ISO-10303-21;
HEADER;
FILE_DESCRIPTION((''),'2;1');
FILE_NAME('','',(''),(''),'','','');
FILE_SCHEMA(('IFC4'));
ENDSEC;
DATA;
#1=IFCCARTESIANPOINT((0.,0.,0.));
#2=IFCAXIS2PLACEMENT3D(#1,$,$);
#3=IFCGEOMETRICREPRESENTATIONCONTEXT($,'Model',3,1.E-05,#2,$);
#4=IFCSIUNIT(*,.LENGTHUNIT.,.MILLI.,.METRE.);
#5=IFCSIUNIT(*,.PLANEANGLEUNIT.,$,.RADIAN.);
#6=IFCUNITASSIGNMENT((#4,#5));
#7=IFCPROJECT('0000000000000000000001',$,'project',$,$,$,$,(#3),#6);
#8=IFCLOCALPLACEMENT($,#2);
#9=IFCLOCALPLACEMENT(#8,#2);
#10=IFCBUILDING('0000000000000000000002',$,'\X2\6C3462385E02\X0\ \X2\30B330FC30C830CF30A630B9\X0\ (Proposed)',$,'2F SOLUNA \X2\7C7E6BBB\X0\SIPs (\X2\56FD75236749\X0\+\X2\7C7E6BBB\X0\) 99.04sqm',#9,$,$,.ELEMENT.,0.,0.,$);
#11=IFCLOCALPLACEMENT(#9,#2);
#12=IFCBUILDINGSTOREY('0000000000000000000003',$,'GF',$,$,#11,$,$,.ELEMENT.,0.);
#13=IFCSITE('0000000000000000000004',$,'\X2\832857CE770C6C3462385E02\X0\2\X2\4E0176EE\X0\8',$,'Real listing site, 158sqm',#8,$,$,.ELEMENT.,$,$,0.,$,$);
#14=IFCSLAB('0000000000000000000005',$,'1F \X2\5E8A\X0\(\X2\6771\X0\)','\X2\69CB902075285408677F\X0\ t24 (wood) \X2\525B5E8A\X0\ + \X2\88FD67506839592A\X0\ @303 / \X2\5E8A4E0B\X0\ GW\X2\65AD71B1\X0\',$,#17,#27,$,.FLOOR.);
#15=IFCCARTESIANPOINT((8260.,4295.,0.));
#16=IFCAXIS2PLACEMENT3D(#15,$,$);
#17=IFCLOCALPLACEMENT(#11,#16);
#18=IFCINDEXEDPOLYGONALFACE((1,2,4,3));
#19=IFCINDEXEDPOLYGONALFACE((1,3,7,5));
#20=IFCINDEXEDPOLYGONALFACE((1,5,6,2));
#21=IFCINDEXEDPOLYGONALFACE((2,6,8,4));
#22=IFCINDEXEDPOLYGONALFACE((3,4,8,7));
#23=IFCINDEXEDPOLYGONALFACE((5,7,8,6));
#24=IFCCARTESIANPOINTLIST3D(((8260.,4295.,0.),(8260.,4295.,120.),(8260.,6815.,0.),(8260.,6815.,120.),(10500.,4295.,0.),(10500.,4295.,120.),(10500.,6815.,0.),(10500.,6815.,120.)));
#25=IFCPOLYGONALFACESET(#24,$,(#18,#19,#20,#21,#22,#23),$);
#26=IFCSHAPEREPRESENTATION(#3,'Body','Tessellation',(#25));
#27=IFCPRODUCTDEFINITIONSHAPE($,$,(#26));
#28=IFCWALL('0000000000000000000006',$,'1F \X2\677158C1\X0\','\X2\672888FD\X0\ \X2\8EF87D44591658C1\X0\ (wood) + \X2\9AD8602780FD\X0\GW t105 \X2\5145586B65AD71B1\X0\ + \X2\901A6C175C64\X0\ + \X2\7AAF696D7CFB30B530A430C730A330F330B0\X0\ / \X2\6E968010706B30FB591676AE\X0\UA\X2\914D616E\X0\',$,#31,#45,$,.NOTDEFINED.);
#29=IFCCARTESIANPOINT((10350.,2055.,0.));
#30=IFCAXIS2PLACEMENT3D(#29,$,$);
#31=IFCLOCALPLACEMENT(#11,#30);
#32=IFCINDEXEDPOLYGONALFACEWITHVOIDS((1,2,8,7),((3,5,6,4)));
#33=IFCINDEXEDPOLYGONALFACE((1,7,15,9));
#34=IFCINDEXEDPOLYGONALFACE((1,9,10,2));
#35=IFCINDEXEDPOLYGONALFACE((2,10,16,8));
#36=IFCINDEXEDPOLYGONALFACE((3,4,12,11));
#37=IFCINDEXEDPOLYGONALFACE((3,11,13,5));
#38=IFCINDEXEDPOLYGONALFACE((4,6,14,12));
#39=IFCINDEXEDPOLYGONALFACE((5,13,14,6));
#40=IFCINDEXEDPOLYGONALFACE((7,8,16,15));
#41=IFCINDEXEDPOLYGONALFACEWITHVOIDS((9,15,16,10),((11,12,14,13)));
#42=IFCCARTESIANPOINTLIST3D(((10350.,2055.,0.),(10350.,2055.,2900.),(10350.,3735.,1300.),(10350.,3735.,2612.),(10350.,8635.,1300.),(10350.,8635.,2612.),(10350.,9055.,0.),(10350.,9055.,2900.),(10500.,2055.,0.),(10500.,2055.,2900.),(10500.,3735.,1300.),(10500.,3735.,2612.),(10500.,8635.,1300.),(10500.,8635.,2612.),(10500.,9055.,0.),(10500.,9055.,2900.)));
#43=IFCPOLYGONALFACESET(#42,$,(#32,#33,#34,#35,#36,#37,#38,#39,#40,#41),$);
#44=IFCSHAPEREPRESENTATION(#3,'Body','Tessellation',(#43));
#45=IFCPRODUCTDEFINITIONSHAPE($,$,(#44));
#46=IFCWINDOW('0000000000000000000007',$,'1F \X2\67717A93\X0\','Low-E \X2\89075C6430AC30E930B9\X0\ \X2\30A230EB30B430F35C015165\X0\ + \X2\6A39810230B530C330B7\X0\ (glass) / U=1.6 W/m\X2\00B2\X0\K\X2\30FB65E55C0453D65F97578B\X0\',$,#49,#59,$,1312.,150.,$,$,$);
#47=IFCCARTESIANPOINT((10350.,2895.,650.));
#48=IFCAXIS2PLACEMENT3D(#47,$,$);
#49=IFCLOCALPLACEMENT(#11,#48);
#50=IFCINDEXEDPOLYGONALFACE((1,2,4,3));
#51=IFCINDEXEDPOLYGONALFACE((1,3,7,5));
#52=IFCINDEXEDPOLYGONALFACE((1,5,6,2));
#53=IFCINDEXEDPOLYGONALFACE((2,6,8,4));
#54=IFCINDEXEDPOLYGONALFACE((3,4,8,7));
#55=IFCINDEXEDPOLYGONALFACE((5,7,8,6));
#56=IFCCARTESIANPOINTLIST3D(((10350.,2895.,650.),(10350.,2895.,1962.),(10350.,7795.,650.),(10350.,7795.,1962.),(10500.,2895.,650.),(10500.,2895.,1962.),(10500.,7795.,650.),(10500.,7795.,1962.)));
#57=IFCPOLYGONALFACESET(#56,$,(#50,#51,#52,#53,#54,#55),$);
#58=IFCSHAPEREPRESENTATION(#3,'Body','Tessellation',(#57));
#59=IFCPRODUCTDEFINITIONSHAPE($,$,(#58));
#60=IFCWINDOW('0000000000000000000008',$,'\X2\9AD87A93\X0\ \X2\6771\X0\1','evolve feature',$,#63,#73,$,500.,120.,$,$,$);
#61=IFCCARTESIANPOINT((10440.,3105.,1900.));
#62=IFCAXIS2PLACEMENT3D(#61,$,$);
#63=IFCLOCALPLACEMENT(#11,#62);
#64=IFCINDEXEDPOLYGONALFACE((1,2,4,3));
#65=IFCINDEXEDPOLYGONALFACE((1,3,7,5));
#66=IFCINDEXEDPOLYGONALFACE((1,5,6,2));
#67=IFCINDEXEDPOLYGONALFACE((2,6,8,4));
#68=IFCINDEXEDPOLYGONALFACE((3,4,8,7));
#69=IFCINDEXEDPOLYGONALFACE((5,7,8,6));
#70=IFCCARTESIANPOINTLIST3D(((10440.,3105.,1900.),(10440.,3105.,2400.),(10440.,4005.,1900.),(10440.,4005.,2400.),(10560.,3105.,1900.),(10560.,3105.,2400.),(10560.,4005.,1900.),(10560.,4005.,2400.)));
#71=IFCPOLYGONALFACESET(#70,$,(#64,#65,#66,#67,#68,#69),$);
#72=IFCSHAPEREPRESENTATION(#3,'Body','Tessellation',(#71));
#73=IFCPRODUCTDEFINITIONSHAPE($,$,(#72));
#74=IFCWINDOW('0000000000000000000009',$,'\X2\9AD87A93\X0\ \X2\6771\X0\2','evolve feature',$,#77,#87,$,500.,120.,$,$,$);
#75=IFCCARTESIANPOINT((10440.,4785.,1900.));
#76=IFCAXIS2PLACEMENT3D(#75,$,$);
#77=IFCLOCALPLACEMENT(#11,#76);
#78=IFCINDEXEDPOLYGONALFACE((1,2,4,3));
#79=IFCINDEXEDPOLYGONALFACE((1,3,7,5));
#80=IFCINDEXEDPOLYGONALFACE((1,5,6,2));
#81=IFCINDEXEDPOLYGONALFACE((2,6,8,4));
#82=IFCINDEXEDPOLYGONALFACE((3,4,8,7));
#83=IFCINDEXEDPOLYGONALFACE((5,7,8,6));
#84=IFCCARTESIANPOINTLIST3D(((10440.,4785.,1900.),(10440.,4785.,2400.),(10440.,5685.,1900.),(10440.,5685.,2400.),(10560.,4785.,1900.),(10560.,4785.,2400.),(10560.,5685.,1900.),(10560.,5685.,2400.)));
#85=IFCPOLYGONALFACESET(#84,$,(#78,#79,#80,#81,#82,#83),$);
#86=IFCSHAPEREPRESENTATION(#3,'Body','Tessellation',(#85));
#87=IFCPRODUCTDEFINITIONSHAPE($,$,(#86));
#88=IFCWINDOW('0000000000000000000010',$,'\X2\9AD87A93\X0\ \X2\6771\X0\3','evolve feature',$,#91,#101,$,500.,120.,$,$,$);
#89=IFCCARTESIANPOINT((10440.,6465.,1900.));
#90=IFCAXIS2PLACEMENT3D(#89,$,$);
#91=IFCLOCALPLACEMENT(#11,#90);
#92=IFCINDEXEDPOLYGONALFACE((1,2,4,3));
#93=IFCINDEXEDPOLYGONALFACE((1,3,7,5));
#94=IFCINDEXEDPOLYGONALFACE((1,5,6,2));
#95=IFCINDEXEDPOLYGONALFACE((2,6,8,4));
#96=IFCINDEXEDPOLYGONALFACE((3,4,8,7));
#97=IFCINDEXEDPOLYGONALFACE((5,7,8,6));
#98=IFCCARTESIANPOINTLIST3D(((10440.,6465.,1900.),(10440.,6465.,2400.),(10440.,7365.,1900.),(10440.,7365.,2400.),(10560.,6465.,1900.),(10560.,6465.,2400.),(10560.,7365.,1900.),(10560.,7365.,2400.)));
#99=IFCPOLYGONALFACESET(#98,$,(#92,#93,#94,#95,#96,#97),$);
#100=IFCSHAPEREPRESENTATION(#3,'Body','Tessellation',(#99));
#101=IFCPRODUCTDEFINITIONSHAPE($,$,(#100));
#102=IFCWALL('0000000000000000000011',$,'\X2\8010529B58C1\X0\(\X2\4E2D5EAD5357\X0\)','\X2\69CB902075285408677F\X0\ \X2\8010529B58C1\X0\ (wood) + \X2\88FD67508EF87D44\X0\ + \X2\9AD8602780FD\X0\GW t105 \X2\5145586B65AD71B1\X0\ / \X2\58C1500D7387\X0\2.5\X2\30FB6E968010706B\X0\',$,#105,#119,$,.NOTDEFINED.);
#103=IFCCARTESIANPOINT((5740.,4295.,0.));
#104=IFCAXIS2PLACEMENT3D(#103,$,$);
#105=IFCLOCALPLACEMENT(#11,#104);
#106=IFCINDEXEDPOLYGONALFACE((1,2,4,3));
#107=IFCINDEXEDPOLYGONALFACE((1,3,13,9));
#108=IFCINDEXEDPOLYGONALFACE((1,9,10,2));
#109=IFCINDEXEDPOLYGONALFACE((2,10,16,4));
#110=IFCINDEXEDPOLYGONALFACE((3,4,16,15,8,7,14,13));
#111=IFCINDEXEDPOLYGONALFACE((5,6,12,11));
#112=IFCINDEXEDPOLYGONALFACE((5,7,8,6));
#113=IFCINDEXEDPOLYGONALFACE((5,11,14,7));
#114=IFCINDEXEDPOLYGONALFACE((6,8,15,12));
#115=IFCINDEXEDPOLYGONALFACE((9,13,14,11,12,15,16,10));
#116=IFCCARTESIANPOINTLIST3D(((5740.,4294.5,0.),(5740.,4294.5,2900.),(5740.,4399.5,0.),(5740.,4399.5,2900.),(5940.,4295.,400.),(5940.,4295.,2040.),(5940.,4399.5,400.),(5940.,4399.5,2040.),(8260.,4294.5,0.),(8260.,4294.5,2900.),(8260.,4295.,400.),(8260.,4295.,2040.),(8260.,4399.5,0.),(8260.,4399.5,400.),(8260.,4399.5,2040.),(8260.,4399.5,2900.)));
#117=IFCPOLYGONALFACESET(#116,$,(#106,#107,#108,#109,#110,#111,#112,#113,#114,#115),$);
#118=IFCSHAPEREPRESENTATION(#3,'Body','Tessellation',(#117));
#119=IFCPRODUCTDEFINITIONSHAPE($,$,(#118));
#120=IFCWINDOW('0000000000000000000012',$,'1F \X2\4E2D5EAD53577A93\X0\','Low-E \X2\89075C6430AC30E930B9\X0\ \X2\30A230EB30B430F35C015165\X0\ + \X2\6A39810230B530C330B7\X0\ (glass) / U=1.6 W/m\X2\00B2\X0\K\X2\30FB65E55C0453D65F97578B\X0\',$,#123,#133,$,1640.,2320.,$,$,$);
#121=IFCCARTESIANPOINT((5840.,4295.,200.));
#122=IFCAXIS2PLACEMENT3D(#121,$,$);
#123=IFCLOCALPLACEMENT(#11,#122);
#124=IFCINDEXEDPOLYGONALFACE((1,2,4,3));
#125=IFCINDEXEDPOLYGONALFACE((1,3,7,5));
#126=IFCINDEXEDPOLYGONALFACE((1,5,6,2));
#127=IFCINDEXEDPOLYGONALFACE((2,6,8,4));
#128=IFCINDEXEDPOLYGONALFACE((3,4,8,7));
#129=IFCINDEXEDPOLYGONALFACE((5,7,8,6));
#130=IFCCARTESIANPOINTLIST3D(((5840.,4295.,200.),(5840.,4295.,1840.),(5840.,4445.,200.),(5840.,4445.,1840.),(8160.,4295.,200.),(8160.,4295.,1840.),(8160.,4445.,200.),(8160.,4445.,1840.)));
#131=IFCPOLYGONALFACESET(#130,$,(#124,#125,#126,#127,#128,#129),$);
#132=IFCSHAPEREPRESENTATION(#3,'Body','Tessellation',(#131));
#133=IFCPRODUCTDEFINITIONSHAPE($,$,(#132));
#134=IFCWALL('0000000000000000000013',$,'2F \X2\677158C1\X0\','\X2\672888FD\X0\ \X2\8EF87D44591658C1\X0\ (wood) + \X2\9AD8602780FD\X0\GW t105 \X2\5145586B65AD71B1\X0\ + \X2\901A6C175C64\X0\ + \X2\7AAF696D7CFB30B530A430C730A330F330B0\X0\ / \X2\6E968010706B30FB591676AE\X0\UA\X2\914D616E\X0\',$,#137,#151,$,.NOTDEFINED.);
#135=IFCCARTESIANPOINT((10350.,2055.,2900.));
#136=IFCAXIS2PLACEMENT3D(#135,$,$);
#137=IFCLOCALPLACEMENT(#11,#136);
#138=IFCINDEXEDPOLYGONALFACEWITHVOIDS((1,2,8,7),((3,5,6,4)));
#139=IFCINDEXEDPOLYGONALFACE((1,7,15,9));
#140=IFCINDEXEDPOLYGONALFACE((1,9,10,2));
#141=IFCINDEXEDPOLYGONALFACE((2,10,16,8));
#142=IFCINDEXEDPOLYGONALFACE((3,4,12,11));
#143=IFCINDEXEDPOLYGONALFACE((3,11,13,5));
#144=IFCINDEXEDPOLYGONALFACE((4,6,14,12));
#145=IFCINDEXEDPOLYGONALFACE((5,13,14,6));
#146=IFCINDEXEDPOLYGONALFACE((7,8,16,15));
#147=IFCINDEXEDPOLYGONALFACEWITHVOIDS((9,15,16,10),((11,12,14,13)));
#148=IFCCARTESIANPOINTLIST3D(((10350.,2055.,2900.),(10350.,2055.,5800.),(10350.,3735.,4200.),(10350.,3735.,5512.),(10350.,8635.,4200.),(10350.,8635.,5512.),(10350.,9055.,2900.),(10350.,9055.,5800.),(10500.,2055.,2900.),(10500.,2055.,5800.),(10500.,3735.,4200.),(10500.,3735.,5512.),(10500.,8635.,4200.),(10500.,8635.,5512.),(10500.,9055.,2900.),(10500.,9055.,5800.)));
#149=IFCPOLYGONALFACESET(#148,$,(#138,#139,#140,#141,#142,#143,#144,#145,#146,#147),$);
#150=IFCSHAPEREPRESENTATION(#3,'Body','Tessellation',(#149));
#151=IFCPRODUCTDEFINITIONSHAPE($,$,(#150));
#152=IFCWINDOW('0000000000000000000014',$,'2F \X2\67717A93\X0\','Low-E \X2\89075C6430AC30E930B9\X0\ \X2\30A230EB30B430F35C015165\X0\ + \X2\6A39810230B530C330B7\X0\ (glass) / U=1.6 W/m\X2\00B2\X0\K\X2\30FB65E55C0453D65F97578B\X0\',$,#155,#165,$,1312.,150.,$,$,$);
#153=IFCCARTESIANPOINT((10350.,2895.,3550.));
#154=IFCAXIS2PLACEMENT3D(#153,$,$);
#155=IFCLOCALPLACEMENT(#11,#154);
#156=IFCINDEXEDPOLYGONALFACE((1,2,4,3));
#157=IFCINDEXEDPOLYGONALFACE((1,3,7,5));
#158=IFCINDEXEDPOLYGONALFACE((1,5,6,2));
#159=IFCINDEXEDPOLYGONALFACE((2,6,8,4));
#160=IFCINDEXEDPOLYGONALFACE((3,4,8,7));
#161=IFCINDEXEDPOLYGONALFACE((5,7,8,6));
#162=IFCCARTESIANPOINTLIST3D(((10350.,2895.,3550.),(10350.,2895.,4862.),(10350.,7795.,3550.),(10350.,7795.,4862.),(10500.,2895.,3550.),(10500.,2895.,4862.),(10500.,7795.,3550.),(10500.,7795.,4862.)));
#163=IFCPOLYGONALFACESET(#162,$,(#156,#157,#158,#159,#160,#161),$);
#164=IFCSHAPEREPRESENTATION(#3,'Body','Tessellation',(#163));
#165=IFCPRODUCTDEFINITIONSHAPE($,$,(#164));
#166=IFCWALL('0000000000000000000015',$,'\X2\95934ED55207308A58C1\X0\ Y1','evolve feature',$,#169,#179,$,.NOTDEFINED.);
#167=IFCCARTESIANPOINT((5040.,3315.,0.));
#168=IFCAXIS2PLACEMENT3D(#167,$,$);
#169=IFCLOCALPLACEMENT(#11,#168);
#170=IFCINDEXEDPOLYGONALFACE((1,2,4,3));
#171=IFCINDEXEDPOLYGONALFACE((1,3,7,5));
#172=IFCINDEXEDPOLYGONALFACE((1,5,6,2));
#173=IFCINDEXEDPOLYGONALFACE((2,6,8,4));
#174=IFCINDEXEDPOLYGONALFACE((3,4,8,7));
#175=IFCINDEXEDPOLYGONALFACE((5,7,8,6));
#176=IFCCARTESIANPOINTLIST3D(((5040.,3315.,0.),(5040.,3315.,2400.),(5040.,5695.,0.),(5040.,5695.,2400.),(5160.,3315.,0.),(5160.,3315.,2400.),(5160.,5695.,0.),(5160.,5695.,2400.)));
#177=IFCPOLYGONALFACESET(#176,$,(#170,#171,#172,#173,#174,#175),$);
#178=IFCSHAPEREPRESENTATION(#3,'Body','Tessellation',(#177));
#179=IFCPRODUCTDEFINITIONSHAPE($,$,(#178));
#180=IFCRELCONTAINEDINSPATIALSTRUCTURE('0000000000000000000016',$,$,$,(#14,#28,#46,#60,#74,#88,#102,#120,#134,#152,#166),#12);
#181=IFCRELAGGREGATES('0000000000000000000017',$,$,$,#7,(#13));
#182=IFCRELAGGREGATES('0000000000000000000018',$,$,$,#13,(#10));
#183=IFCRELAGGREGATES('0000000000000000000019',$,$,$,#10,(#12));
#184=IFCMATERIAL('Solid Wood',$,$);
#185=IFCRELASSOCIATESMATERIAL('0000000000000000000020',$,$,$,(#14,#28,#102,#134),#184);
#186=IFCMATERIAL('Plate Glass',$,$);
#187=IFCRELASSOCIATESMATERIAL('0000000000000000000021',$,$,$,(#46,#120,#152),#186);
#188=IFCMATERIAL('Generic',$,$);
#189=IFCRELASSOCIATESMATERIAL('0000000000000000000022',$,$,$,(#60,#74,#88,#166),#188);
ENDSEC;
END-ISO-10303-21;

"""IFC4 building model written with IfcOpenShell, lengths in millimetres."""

from ifc_helpers import new_model, si_unit, frame, frame_2d, origin, place, context, project, spatial, rectangle, extrude, material, element, fill, save


model = new_model("IFC4")

# Units and contexts
model_context = context("Model", 3, precision=1e-05, world=origin())
ifc_project = project(units=[si_unit("LENGTHUNIT", "METRE", prefix="MILLI"), si_unit("PLANEANGLEUNIT", "RADIAN")], contexts=[model_context])

# Site, building, storey
site_placement = place(None, origin())
site = spatial("IfcSite", under=ifc_project, at=site_placement, Name="茨城県水戸市2丁目8", ObjectType="Real listing site, 158sqm", CompositionType="ELEMENT", RefElevation=0.0)
building_placement = place(site_placement, origin())
building = spatial("IfcBuilding", under=site, at=building_placement, Name="水戸市 コートハウス (Proposed)", ObjectType="2F SOLUNA 籾殻SIPs (国産杉+籾殻) 99.04sqm", CompositionType="ELEMENT", ElevationOfRefHeight=0.0, ElevationOfTerrain=0.0)
storey_placement = place(building_placement, origin())
storey = spatial("IfcBuildingStorey", under=building, at=storey_placement, Name="GF", CompositionType="ELEMENT", Elevation=0.0)

# Slab
ifc_material_1 = material(Name="Solid Wood")
slab_placement = place(storey_placement, frame((8260.0, 4295.0, 0.0)))
element("IfcSlab", 1, at=slab_placement, inside=storey, material=ifc_material_1, Name="1F 床(東)", Description="構造用合板 t24 (wood) 剛床 + 製材根太 @303 / 床下 GW断熱", PredefinedType="FLOOR", context=model_context, shape_type="SweptSolid", body=[
    extrude(rectangle(XDim=2240.0, YDim=2520.0, at=frame_2d((1120.0, 1260.0))), frame((8260.0, 4295.0, 0.0)), (0.0, 0.0, 1.0), 120.0),
])

# Wall, openings, windows
wall_1_placement = place(storey_placement, frame((10350.0, 2055.0, 0.0)))
wall_1 = element("IfcWall", 2, at=wall_1_placement, inside=storey, material=ifc_material_1, Name="1F 東壁", Description="木製 軸組外壁 (wood) + 高性能GW t105 充填断熱 + 通気層 + 窯業系サイディング / 準耐火・外皮UA配慮", PredefinedType="NOTDEFINED", context=model_context, shape_type="SweptSolid", body=[
    extrude(rectangle(XDim=150.0, YDim=7000.0, at=frame_2d((75.0, 3500.0))), frame((10350.0, 2055.0, 0.0)), (0.0, 0.0, 1.0), 2900.0),
])
opening_1_placement = place(storey_placement, frame((10350.0, 2895.0, 650.0)))
opening_1 = element("IfcOpeningElement", 3, at=opening_1_placement, cuts=wall_1, PredefinedType="NOTDEFINED", context=model_context, shape_type="SweptSolid", body=[
    extrude(rectangle(XDim=150.0, YDim=4900.0, at=frame_2d((75.0, 2450.0))), frame((10350.0, 2895.0, 650.0)), (0.0, 0.0, 1.0), 1312.0),
])
opening_2_placement = place(storey_placement, frame((10440.0, 3105.0, 1900.0)))
opening_2 = element("IfcOpeningElement", 4, at=opening_2_placement, cuts=wall_1, PredefinedType="NOTDEFINED", context=model_context, shape_type="SweptSolid", body=[
    extrude(rectangle(XDim=120.0, YDim=900.0, at=frame_2d((60.0, 450.0))), frame((10440.0, 3105.0, 1900.0)), (0.0, 0.0, 1.0), 500.0),
])
opening_3_placement = place(storey_placement, frame((10440.0, 4785.0, 1900.0)))
opening_3 = element("IfcOpeningElement", 5, at=opening_3_placement, cuts=wall_1, PredefinedType="NOTDEFINED", context=model_context, shape_type="SweptSolid", body=[
    extrude(rectangle(XDim=120.0, YDim=900.0, at=frame_2d((60.0, 450.0))), frame((10440.0, 4785.0, 1900.0)), (0.0, 0.0, 1.0), 500.0),
])
opening_4_placement = place(storey_placement, frame((10440.0, 6465.0, 1900.0)))
opening_4 = element("IfcOpeningElement", 6, at=opening_4_placement, cuts=wall_1, PredefinedType="NOTDEFINED", context=model_context, shape_type="SweptSolid", body=[
    extrude(rectangle(XDim=120.0, YDim=900.0, at=frame_2d((60.0, 450.0))), frame((10440.0, 6465.0, 1900.0)), (0.0, 0.0, 1.0), 500.0),
])
ifc_material_2 = material(Name="Plate Glass")
window_1_placement = place(storey_placement, frame((10350.0, 2895.0, 650.0)))
window_1 = element("IfcWindow", 7, at=window_1_placement, inside=storey, material=ifc_material_2, Name="1F 東窓", Description="Low-E 複層ガラス アルゴン封入 + 樹脂サッシ (glass) / U=1.6 W/m²K・日射取得型", OverallHeight=1312.0, OverallWidth=150.0, context=model_context, shape_type="SweptSolid", body=[
    extrude(rectangle(XDim=150.0, YDim=4900.0, at=frame_2d((75.0, 2450.0))), frame((10350.0, 2895.0, 650.0)), (0.0, 0.0, 1.0), 1312.0),
])
fill(opening_1, window_1)
ifc_material_3 = material(Name="Generic")
window_2_placement = place(storey_placement, frame((10440.0, 3105.0, 1900.0)))
window_2 = element("IfcWindow", 8, at=window_2_placement, inside=storey, material=ifc_material_3, Name="高窓 東1", Description="evolve feature", OverallHeight=500.0, OverallWidth=120.0, context=model_context, shape_type="SweptSolid", body=[
    extrude(rectangle(XDim=120.0, YDim=900.0, at=frame_2d((60.0, 450.0))), frame((10440.0, 3105.0, 1900.0)), (0.0, 0.0, 1.0), 500.0),
])
fill(opening_2, window_2)
window_3_placement = place(storey_placement, frame((10440.0, 4785.0, 1900.0)))
window_3 = element("IfcWindow", 9, at=window_3_placement, inside=storey, material=ifc_material_3, Name="高窓 東2", Description="evolve feature", OverallHeight=500.0, OverallWidth=120.0, context=model_context, shape_type="SweptSolid", body=[
    extrude(rectangle(XDim=120.0, YDim=900.0, at=frame_2d((60.0, 450.0))), frame((10440.0, 4785.0, 1900.0)), (0.0, 0.0, 1.0), 500.0),
])
fill(opening_3, window_3)
window_4_placement = place(storey_placement, frame((10440.0, 6465.0, 1900.0)))
window_4 = element("IfcWindow", 10, at=window_4_placement, inside=storey, material=ifc_material_3, Name="高窓 東3", Description="evolve feature", OverallHeight=500.0, OverallWidth=120.0, context=model_context, shape_type="SweptSolid", body=[
    extrude(rectangle(XDim=120.0, YDim=900.0, at=frame_2d((60.0, 450.0))), frame((10440.0, 6465.0, 1900.0)), (0.0, 0.0, 1.0), 500.0),
])
fill(opening_4, window_4)

# Wall, opening, window
wall_2_placement = place(storey_placement, frame((5740.0, 4295.0, 0.0)))
wall_2 = element("IfcWall", 11, at=wall_2_placement, inside=storey, material=ifc_material_1, Name="耐力壁(中庭南)", Description="構造用合板 耐力壁 (wood) + 製材軸組 + 高性能GW t105 充填断熱 / 壁倍率2.5・準耐火", PredefinedType="NOTDEFINED", context=model_context, shape_type="SweptSolid", body=[
    extrude(rectangle(XDim=2520.0, YDim=105.0, at=frame_2d((1260.0, 52.0))), frame((5740.0, 4295.0, 0.0)), (0.0, 0.0, 1.0), 2900.0),
])
opening_5_placement = place(storey_placement, frame((5840.0, 4295.0, 200.0)))
opening_5 = element("IfcOpeningElement", 12, at=opening_5_placement, cuts=wall_2, PredefinedType="NOTDEFINED", context=model_context, shape_type="SweptSolid", body=[
    extrude(rectangle(XDim=2320.0, YDim=150.0, at=frame_2d((1160.0, 75.0))), frame((5840.0, 4295.0, 200.0)), (0.0, 0.0, 1.0), 1640.0),
])
window_5_placement = place(storey_placement, frame((5840.0, 4295.0, 200.0)))
window_5 = element("IfcWindow", 13, at=window_5_placement, inside=storey, material=ifc_material_2, Name="1F 中庭南窓", Description="Low-E 複層ガラス アルゴン封入 + 樹脂サッシ (glass) / U=1.6 W/m²K・日射取得型", OverallHeight=1640.0, OverallWidth=2320.0, context=model_context, shape_type="SweptSolid", body=[
    extrude(rectangle(XDim=2320.0, YDim=150.0, at=frame_2d((1160.0, 75.0))), frame((5840.0, 4295.0, 200.0)), (0.0, 0.0, 1.0), 1640.0),
])
fill(opening_5, window_5)

# Wall, opening, window
wall_3_placement = place(storey_placement, frame((10350.0, 2055.0, 2900.0)))
wall_3 = element("IfcWall", 14, at=wall_3_placement, inside=storey, material=ifc_material_1, Name="2F 東壁", Description="木製 軸組外壁 (wood) + 高性能GW t105 充填断熱 + 通気層 + 窯業系サイディング / 準耐火・外皮UA配慮", PredefinedType="NOTDEFINED", context=model_context, shape_type="SweptSolid", body=[
    extrude(rectangle(XDim=150.0, YDim=7000.0, at=frame_2d((75.0, 3500.0))), frame((10350.0, 2055.0, 2900.0)), (0.0, 0.0, 1.0), 2900.0),
])
opening_6_placement = place(storey_placement, frame((10350.0, 2895.0, 3550.0)))
opening_6 = element("IfcOpeningElement", 15, at=opening_6_placement, cuts=wall_3, PredefinedType="NOTDEFINED", context=model_context, shape_type="SweptSolid", body=[
    extrude(rectangle(XDim=150.0, YDim=4900.0, at=frame_2d((75.0, 2450.0))), frame((10350.0, 2895.0, 3550.0)), (0.0, 0.0, 1.0), 1312.0),
])
window_6_placement = place(storey_placement, frame((10350.0, 2895.0, 3550.0)))
window_6 = element("IfcWindow", 16, at=window_6_placement, inside=storey, material=ifc_material_2, Name="2F 東窓", Description="Low-E 複層ガラス アルゴン封入 + 樹脂サッシ (glass) / U=1.6 W/m²K・日射取得型", OverallHeight=1312.0, OverallWidth=150.0, context=model_context, shape_type="SweptSolid", body=[
    extrude(rectangle(XDim=150.0, YDim=4900.0, at=frame_2d((75.0, 2450.0))), frame((10350.0, 2895.0, 3550.0)), (0.0, 0.0, 1.0), 1312.0),
])
fill(opening_6, window_6)

# Wall
wall_4_placement = place(storey_placement, frame((5040.0, 3315.0, 0.0)))
element("IfcWall", 17, at=wall_4_placement, inside=storey, material=ifc_material_3, Name="間仕切り壁 Y1", Description="evolve feature", PredefinedType="NOTDEFINED", context=model_context, shape_type="SweptSolid", body=[
    extrude(rectangle(XDim=120.0, YDim=2380.0, at=frame_2d((60.0, 1190.0))), frame((5040.0, 3315.0, 0.0)), (0.0, 0.0, 1.0), 2400.0),
])

save(model, "model.ifc")
